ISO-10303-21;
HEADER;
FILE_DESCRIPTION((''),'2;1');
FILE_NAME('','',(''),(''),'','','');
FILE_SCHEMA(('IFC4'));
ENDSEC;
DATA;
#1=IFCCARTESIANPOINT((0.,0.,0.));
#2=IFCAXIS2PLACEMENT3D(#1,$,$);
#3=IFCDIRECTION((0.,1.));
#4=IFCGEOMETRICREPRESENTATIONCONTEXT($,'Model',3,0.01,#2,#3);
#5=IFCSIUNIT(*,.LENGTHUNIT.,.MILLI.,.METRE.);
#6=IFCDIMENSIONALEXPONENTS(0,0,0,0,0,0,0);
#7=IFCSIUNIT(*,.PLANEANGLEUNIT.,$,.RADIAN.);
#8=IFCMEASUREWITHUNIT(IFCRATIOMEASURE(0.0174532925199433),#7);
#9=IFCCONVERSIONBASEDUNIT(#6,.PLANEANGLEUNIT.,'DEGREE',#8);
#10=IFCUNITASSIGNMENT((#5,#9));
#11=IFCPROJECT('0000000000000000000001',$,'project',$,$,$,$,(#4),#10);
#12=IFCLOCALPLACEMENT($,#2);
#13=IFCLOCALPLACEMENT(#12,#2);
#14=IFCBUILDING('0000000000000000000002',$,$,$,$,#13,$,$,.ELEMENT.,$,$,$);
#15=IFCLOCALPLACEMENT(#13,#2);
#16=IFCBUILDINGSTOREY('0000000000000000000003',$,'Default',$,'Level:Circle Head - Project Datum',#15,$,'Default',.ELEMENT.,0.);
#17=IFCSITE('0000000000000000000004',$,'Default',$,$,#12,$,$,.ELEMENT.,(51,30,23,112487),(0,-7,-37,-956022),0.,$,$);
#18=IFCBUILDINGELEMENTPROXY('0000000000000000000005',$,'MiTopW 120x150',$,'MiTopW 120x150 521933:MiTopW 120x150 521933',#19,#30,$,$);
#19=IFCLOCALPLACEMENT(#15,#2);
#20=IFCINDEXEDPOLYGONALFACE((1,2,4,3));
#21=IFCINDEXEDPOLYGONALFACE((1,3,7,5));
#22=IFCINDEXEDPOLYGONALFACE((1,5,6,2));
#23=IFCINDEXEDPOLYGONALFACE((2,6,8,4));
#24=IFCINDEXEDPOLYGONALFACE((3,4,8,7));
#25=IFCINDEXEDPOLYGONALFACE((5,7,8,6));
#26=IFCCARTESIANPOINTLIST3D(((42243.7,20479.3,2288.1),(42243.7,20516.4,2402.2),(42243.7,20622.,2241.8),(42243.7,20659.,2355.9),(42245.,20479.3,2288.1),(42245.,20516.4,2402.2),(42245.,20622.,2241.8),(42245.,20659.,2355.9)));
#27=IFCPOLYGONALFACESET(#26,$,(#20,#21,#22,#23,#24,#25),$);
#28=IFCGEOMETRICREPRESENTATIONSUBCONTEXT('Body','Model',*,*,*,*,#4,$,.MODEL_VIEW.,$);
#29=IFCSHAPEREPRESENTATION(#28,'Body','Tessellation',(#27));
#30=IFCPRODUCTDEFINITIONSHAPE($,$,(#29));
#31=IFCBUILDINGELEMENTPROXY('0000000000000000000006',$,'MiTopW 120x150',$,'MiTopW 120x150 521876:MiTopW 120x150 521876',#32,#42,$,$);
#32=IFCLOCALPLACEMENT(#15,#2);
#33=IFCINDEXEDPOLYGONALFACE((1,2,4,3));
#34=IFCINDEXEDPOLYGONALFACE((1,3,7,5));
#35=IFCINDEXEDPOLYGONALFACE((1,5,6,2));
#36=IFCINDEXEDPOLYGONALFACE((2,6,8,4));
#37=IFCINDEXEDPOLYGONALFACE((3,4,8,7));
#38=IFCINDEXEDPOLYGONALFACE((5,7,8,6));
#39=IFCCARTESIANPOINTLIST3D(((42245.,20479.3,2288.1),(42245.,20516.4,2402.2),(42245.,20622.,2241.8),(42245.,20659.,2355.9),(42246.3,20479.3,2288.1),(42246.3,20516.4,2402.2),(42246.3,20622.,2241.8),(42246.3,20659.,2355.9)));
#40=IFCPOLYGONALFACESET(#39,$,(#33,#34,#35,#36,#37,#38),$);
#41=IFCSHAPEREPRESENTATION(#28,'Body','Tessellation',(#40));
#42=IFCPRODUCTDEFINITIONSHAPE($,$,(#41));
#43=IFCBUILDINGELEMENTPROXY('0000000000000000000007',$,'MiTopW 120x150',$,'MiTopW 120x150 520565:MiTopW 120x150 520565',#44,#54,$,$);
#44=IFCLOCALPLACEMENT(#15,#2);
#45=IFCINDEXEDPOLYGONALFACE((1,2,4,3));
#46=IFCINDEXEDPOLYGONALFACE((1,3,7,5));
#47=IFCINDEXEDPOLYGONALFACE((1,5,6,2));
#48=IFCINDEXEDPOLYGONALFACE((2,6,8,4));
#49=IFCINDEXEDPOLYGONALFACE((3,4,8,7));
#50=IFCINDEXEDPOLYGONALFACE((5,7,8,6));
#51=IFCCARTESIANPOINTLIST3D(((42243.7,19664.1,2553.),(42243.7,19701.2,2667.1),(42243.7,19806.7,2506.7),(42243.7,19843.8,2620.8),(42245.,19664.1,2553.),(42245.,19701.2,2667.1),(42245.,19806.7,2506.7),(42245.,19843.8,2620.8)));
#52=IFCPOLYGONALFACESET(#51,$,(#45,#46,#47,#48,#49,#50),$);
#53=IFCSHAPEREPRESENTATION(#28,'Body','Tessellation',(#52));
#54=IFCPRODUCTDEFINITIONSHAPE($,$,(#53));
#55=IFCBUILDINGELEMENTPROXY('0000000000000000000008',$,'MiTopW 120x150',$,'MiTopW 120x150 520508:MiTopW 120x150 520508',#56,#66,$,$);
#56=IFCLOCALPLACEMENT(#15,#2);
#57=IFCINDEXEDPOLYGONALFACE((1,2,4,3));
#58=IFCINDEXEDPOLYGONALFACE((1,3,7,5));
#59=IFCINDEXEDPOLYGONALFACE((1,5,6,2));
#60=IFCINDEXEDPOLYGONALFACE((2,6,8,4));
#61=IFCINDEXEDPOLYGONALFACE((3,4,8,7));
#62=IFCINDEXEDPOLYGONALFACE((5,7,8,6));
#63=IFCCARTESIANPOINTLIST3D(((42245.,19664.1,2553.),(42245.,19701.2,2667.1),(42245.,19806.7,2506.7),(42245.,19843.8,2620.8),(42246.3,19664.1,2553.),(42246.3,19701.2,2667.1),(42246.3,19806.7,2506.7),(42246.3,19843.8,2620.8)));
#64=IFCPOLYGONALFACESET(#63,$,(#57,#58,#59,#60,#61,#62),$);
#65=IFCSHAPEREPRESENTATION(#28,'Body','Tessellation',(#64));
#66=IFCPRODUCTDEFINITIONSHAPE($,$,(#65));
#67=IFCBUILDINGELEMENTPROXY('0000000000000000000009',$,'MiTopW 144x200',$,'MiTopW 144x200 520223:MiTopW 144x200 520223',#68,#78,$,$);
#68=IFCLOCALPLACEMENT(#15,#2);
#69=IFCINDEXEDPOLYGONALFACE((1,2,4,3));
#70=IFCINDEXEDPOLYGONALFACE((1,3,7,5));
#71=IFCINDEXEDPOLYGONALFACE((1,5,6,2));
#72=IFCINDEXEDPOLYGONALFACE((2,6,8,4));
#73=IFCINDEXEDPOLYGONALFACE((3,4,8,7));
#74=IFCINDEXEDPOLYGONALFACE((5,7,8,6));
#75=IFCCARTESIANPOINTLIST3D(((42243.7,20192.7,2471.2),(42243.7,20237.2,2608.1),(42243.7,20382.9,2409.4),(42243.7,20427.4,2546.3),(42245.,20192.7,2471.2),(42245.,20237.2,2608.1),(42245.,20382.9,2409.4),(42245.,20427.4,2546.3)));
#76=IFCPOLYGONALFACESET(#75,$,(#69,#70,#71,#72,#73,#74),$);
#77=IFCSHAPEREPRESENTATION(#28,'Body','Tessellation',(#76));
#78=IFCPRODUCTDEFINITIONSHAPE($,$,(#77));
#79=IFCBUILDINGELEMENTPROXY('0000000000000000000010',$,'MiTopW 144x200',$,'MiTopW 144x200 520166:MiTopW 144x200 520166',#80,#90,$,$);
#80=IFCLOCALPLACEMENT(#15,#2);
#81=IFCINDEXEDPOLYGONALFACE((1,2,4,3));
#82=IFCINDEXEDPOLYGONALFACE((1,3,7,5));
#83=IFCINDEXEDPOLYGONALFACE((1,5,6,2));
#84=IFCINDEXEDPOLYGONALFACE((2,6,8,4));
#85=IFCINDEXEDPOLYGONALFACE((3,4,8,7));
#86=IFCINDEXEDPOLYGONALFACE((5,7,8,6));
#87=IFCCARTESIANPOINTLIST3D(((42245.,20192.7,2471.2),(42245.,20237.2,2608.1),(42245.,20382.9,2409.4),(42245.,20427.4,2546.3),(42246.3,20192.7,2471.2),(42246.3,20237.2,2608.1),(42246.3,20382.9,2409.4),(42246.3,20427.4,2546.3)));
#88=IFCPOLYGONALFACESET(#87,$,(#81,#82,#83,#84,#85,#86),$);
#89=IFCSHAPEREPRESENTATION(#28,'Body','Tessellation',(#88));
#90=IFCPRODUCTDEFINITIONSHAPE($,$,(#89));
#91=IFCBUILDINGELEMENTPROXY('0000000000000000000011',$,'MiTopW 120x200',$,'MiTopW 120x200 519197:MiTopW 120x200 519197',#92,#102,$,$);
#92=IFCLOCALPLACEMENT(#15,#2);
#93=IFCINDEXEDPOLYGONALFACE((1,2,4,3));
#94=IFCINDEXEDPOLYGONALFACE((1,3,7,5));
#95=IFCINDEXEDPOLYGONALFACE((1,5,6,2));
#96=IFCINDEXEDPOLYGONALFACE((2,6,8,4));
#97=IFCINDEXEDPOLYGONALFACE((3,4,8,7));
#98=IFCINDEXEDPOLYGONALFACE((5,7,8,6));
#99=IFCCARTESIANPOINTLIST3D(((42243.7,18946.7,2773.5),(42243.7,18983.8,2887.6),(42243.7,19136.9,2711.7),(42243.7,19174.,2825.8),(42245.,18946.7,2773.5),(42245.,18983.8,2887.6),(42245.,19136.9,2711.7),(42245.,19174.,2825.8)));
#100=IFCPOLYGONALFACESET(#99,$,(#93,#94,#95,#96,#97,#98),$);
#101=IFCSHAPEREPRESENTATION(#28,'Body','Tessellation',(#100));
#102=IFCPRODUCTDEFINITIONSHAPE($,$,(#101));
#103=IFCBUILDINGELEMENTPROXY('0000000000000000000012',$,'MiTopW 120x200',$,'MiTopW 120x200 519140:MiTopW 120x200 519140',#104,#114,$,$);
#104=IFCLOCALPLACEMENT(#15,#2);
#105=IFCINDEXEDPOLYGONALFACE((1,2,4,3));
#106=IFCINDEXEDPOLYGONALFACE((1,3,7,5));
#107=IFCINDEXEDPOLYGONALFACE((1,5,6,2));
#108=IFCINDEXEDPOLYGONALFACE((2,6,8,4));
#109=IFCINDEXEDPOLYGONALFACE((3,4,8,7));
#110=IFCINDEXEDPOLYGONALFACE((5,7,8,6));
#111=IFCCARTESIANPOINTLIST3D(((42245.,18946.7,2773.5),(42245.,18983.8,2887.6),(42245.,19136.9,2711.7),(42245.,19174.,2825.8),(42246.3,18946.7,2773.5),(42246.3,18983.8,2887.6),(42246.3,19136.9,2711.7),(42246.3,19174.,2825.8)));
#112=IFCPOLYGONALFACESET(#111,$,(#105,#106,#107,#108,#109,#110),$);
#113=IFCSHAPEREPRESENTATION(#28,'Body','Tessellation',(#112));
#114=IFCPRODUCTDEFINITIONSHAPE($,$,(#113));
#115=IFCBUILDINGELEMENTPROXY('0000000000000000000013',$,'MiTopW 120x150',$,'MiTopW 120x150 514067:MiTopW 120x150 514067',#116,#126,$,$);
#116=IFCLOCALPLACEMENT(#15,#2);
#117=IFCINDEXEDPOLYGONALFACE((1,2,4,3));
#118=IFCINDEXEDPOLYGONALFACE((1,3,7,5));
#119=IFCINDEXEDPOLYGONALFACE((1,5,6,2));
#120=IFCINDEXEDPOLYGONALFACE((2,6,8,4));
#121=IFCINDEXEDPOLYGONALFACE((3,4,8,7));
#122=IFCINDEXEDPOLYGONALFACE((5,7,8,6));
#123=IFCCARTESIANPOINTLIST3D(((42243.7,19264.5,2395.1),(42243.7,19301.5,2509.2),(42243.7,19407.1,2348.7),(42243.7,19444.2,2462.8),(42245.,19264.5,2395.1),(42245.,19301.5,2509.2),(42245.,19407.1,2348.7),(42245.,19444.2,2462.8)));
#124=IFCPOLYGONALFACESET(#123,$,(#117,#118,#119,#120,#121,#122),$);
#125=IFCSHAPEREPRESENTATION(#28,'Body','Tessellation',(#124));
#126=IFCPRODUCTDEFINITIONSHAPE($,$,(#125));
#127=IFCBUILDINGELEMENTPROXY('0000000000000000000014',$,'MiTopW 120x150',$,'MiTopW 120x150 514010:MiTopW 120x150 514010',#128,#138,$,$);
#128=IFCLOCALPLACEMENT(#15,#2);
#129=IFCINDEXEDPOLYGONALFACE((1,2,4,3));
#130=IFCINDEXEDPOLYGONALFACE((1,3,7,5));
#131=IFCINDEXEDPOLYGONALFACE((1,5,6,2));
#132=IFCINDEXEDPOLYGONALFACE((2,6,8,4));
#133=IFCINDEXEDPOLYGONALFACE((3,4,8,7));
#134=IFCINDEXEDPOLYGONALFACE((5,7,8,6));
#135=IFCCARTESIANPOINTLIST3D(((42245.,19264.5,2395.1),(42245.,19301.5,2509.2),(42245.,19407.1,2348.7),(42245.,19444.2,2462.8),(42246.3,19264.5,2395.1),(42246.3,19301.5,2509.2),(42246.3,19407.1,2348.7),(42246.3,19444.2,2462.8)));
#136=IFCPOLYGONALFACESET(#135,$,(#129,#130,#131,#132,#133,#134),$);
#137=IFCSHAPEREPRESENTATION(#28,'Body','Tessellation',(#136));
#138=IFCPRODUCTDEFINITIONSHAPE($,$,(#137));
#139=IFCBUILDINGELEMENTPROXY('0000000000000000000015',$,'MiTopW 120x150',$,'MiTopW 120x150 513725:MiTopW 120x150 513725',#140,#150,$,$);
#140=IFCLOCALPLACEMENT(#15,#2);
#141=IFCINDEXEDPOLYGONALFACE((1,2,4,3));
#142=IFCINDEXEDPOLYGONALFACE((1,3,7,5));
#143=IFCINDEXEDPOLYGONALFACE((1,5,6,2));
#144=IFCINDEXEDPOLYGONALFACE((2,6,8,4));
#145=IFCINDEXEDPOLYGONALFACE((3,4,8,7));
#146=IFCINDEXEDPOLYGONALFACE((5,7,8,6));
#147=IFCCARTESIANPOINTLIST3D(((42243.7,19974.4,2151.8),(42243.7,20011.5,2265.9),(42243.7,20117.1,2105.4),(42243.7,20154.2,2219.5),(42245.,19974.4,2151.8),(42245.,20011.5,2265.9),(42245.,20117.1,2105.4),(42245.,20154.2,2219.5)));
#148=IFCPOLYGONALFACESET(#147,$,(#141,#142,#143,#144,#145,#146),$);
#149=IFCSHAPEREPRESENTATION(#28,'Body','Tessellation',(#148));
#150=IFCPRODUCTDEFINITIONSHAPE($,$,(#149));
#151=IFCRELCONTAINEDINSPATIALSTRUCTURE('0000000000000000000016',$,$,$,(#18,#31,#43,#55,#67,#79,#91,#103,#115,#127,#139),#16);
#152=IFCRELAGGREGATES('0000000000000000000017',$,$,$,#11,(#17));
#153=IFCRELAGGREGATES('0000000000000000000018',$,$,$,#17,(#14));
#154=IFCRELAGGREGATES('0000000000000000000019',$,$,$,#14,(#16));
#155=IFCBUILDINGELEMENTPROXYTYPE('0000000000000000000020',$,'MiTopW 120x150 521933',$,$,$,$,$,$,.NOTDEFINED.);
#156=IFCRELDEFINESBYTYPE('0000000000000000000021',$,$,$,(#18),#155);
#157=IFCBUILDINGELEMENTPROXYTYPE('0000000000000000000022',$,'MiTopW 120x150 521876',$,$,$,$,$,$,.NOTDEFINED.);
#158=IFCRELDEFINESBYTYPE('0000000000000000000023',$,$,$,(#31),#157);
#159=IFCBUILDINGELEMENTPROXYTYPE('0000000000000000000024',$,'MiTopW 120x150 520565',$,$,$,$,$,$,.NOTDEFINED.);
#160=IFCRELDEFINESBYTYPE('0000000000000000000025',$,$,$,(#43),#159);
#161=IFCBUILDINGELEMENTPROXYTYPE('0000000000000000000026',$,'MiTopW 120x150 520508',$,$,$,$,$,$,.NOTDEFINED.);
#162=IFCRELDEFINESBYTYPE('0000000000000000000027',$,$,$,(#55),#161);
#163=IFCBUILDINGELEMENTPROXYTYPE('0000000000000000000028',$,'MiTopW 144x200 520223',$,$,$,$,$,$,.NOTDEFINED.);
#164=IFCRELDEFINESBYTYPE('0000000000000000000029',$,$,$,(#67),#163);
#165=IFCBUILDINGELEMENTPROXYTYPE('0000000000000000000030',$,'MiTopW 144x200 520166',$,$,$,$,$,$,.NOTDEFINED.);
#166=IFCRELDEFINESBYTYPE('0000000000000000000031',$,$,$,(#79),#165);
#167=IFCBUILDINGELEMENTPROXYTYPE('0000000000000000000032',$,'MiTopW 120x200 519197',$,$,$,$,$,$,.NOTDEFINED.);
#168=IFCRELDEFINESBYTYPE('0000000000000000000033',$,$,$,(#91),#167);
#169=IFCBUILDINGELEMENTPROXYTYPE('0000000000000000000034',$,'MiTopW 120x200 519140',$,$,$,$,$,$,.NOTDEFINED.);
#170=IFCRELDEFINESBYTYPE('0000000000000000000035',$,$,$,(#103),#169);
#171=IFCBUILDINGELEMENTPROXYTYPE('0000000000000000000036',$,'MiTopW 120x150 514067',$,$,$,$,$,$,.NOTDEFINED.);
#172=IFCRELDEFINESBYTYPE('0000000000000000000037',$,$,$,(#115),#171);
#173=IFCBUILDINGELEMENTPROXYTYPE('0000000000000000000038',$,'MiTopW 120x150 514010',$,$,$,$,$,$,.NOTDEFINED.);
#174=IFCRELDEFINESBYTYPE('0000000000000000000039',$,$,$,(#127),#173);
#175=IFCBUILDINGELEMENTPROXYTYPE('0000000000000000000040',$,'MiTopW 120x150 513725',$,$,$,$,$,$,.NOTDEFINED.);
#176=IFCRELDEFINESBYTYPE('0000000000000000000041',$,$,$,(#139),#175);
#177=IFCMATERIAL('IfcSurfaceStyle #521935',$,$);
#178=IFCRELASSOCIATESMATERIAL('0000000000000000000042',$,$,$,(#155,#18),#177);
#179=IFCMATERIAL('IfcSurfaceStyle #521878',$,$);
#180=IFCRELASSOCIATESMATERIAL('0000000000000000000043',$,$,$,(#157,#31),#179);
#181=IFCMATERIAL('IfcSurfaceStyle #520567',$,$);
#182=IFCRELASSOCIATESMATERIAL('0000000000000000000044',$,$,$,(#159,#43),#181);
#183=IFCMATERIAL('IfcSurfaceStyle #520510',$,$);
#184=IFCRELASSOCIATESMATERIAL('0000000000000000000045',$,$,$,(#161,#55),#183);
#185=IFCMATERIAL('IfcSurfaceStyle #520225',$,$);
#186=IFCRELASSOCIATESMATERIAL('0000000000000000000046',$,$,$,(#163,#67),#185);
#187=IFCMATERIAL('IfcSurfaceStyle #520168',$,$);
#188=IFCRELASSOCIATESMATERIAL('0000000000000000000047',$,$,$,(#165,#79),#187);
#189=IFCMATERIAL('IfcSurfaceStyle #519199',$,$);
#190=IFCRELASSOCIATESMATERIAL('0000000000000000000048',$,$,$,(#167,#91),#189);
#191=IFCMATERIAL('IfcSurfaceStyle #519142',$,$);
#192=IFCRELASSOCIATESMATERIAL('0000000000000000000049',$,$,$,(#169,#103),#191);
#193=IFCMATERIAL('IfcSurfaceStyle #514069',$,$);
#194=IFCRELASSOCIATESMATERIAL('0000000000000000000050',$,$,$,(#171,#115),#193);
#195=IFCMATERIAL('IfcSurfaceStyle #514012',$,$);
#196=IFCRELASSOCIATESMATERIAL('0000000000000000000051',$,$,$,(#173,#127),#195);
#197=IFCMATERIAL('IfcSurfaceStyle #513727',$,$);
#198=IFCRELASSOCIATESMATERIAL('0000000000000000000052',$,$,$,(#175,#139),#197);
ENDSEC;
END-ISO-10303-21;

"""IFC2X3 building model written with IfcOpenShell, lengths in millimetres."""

from ifc_helpers import new_model, entity, si_unit, converted_unit, direction, frame, origin, place, context, subcontext, project, spatial, polyline, outline, extrude, source, transform, mapped, material, type_object, type_shapes, element, save


model = new_model("IFC2X3")

# Units and contexts
model_context = context("Model", 3, precision=0.01, world=origin(), true_north=direction((0.0, 1.0)))
body_context = subcontext(model_context, "Body", "Model", "MODEL_VIEW")
ifc_project = project(units=[si_unit("LENGTHUNIT", "METRE", prefix="MILLI"), converted_unit("PLANEANGLEUNIT", "DEGREE", entity("IfcRatioMeasure", 0.0174532925199433), si_unit("PLANEANGLEUNIT", "RADIAN"), dimensions=[0, 0, 0, 0, 0, 0, 0])], contexts=[model_context])

# Site, building, storey
site_placement = place(None, origin())
site = spatial("IfcSite", under=ifc_project, at=site_placement, Name="Default", CompositionType="ELEMENT", RefLatitude=(51, 30, 23, 112487), RefLongitude=(0, -7, -37, -956022), RefElevation=0.0)
building_placement = place(site_placement, origin())
building = spatial("IfcBuilding", under=site, at=building_placement, CompositionType="ELEMENT")
storey_placement = place(building_placement, origin())
storey = spatial("IfcBuildingStorey", under=building, at=storey_placement, Name="Default", ObjectType="Level:Circle Head - Project Datum", LongName="Default", CompositionType="ELEMENT", Elevation=0.0)

# Building element proxies
ifc_material_1 = material(Name="IfcSurfaceStyle #521935")
building_element_proxy_type_1 = type_object("IfcBuildingElementProxyType", Name="MiTopW 120x150 521933", PredefinedType="NOTDEFINED", material=ifc_material_1)
shared_shape_1 = source(origin(), body_context, "Body", "SweptSolid", [
    extrude(outline(polyline([(-75.0, -60.0), (75.0, -60.0), (75.0, 60.0), (-75.0, 60.0), (-75.0, -60.0)])), frame((75.0, 60.0, 0.0), z_axis=(0.0, 0.0, 1.0), x_axis=(-1.0, 0.0, 0.0)), (0.0, 0.0, 1.0), 1.3),
])
type_shapes(building_element_proxy_type_1, [shared_shape_1])
proxy_1_placement = place(building_placement, frame((42245.0, 20622.0, 2241.8), z_axis=(-1.0, 0.0, 0.0), x_axis=(0.0, -0.951057, 0.309017)))
element("IfcBuildingElementProxy", 1, at=proxy_1_placement, inside=storey, type_object=building_element_proxy_type_1, material=ifc_material_1, Name="MiTopW 120x150", ObjectType="MiTopW 120x150 521933:MiTopW 120x150 521933", context=body_context, shape_type="MappedRepresentation", body=[
    mapped(shared_shape_1, transform((0.0, 0.0, 0.0), scale=1.0)),
])
ifc_material_2 = material(Name="IfcSurfaceStyle #521878")
building_element_proxy_type_2 = type_object("IfcBuildingElementProxyType", Name="MiTopW 120x150 521876", PredefinedType="NOTDEFINED", material=ifc_material_2)
shared_shape_2 = source(origin(), body_context, "Body", "SweptSolid", [
    extrude(outline(polyline([(-75.0, -60.0), (75.0, -60.0), (75.0, 60.0), (-75.0, 60.0), (-75.0, -60.0)])), frame((75.0, 60.0, 0.0), z_axis=(0.0, 0.0, 1.0), x_axis=(-1.0, 0.0, 0.0)), (0.0, 0.0, 1.0), 1.3),
])
type_shapes(building_element_proxy_type_2, [shared_shape_2])
proxy_2_placement = place(building_placement, frame((42246.3, 20622.0, 2241.8), z_axis=(-1.0, 0.0, 0.0), x_axis=(0.0, -0.951057, 0.309017)))
element("IfcBuildingElementProxy", 2, at=proxy_2_placement, inside=storey, type_object=building_element_proxy_type_2, material=ifc_material_2, Name="MiTopW 120x150", ObjectType="MiTopW 120x150 521876:MiTopW 120x150 521876", context=body_context, shape_type="MappedRepresentation", body=[
    mapped(shared_shape_2, transform((0.0, 0.0, 0.0), scale=1.0)),
])
ifc_material_3 = material(Name="IfcSurfaceStyle #520567")
building_element_proxy_type_3 = type_object("IfcBuildingElementProxyType", Name="MiTopW 120x150 520565", PredefinedType="NOTDEFINED", material=ifc_material_3)
shared_shape_3 = source(origin(), body_context, "Body", "SweptSolid", [
    extrude(outline(polyline([(-75.0, -60.0), (75.0, -60.0), (75.0, 60.0), (-75.0, 60.0), (-75.0, -60.0)])), frame((75.0, 60.0, 0.0), z_axis=(0.0, 0.0, 1.0), x_axis=(-1.0, 0.0, 0.0)), (0.0, 0.0, 1.0), 1.3),
])
type_shapes(building_element_proxy_type_3, [shared_shape_3])
proxy_3_placement = place(building_placement, frame((42245.0, 19806.7, 2506.7), z_axis=(-1.0, 0.0, 0.0), x_axis=(0.0, -0.951057, 0.309017)))
element("IfcBuildingElementProxy", 3, at=proxy_3_placement, inside=storey, type_object=building_element_proxy_type_3, material=ifc_material_3, Name="MiTopW 120x150", ObjectType="MiTopW 120x150 520565:MiTopW 120x150 520565", context=body_context, shape_type="MappedRepresentation", body=[
    mapped(shared_shape_3, transform((0.0, 0.0, 0.0), scale=1.0)),
])
ifc_material_4 = material(Name="IfcSurfaceStyle #520510")
building_element_proxy_type_4 = type_object("IfcBuildingElementProxyType", Name="MiTopW 120x150 520508", PredefinedType="NOTDEFINED", material=ifc_material_4)
shared_shape_4 = source(origin(), body_context, "Body", "SweptSolid", [
    extrude(outline(polyline([(-75.0, -60.0), (75.0, -60.0), (75.0, 60.0), (-75.0, 60.0), (-75.0, -60.0)])), frame((75.0, 60.0, 0.0), z_axis=(0.0, 0.0, 1.0), x_axis=(-1.0, 0.0, 0.0)), (0.0, 0.0, 1.0), 1.3),
])
type_shapes(building_element_proxy_type_4, [shared_shape_4])
proxy_4_placement = place(building_placement, frame((42246.3, 19806.7, 2506.7), z_axis=(-1.0, 0.0, 0.0), x_axis=(0.0, -0.951057, 0.309017)))
element("IfcBuildingElementProxy", 4, at=proxy_4_placement, inside=storey, type_object=building_element_proxy_type_4, material=ifc_material_4, Name="MiTopW 120x150", ObjectType="MiTopW 120x150 520508:MiTopW 120x150 520508", context=body_context, shape_type="MappedRepresentation", body=[
    mapped(shared_shape_4, transform((0.0, 0.0, 0.0), scale=1.0)),
])
ifc_material_5 = material(Name="IfcSurfaceStyle #520225")
building_element_proxy_type_5 = type_object("IfcBuildingElementProxyType", Name="MiTopW 144x200 520223", PredefinedType="NOTDEFINED", material=ifc_material_5)
shared_shape_5 = source(origin(), body_context, "Body", "SweptSolid", [
    extrude(outline(polyline([(-100.0, -72.0), (100.0, -72.0), (100.0, 72.0), (-100.0, 72.0), (-100.0, -72.0)])), frame((100.0, 72.0, 0.0), z_axis=(0.0, 0.0, 1.0), x_axis=(-1.0, 0.0, 0.0)), (0.0, 0.0, 1.0), 1.3),
])
type_shapes(building_element_proxy_type_5, [shared_shape_5])
proxy_5_placement = place(building_placement, frame((42245.0, 20382.9, 2409.4), z_axis=(-1.0, 0.0, 0.0), x_axis=(0.0, -0.951057, 0.309017)))
element("IfcBuildingElementProxy", 5, at=proxy_5_placement, inside=storey, type_object=building_element_proxy_type_5, material=ifc_material_5, Name="MiTopW 144x200", ObjectType="MiTopW 144x200 520223:MiTopW 144x200 520223", context=body_context, shape_type="MappedRepresentation", body=[
    mapped(shared_shape_5, transform((0.0, 0.0, 0.0), scale=1.0)),
])
ifc_material_6 = material(Name="IfcSurfaceStyle #520168")
building_element_proxy_type_6 = type_object("IfcBuildingElementProxyType", Name="MiTopW 144x200 520166", PredefinedType="NOTDEFINED", material=ifc_material_6)
shared_shape_6 = source(origin(), body_context, "Body", "SweptSolid", [
    extrude(outline(polyline([(-100.0, -72.0), (100.0, -72.0), (100.0, 72.0), (-100.0, 72.0), (-100.0, -72.0)])), frame((100.0, 72.0, 0.0), z_axis=(0.0, 0.0, 1.0), x_axis=(-1.0, 0.0, 0.0)), (0.0, 0.0, 1.0), 1.3),
])
type_shapes(building_element_proxy_type_6, [shared_shape_6])
proxy_6_placement = place(building_placement, frame((42246.3, 20382.9, 2409.4), z_axis=(-1.0, 0.0, 0.0), x_axis=(0.0, -0.951057, 0.309017)))
element("IfcBuildingElementProxy", 6, at=proxy_6_placement, inside=storey, type_object=building_element_proxy_type_6, material=ifc_material_6, Name="MiTopW 144x200", ObjectType="MiTopW 144x200 520166:MiTopW 144x200 520166", context=body_context, shape_type="MappedRepresentation", body=[
    mapped(shared_shape_6, transform((0.0, 0.0, 0.0), scale=1.0)),
])
ifc_material_7 = material(Name="IfcSurfaceStyle #519199")
building_element_proxy_type_7 = type_object("IfcBuildingElementProxyType", Name="MiTopW 120x200 519197", PredefinedType="NOTDEFINED", material=ifc_material_7)
shared_shape_7 = source(origin(), body_context, "Body", "SweptSolid", [
    extrude(outline(polyline([(-100.0, -60.0), (100.0, -60.0), (100.0, 60.0), (-100.0, 60.0), (-100.0, -60.0)])), frame((100.0, 60.0, 0.0), z_axis=(0.0, 0.0, 1.0), x_axis=(-1.0, 0.0, 0.0)), (0.0, 0.0, 1.0), 1.3),
])
type_shapes(building_element_proxy_type_7, [shared_shape_7])
proxy_7_placement = place(building_placement, frame((42245.0, 19136.9, 2711.7), z_axis=(-1.0, 0.0, 0.0), x_axis=(0.0, -0.951057, 0.309017)))
element("IfcBuildingElementProxy", 7, at=proxy_7_placement, inside=storey, type_object=building_element_proxy_type_7, material=ifc_material_7, Name="MiTopW 120x200", ObjectType="MiTopW 120x200 519197:MiTopW 120x200 519197", context=body_context, shape_type="MappedRepresentation", body=[
    mapped(shared_shape_7, transform((0.0, 0.0, 0.0), scale=1.0)),
])
ifc_material_8 = material(Name="IfcSurfaceStyle #519142")
building_element_proxy_type_8 = type_object("IfcBuildingElementProxyType", Name="MiTopW 120x200 519140", PredefinedType="NOTDEFINED", material=ifc_material_8)
shared_shape_8 = source(origin(), body_context, "Body", "SweptSolid", [
    extrude(outline(polyline([(-100.0, -60.0), (100.0, -60.0), (100.0, 60.0), (-100.0, 60.0), (-100.0, -60.0)])), frame((100.0, 60.0, 0.0), z_axis=(0.0, 0.0, 1.0), x_axis=(-1.0, 0.0, 0.0)), (0.0, 0.0, 1.0), 1.3),
])
type_shapes(building_element_proxy_type_8, [shared_shape_8])
proxy_8_placement = place(building_placement, frame((42246.3, 19136.9, 2711.7), z_axis=(-1.0, 0.0, 0.0), x_axis=(0.0, -0.951057, 0.309017)))
element("IfcBuildingElementProxy", 8, at=proxy_8_placement, inside=storey, type_object=building_element_proxy_type_8, material=ifc_material_8, Name="MiTopW 120x200", ObjectType="MiTopW 120x200 519140:MiTopW 120x200 519140", context=body_context, shape_type="MappedRepresentation", body=[
    mapped(shared_shape_8, transform((0.0, 0.0, 0.0), scale=1.0)),
])
ifc_material_9 = material(Name="IfcSurfaceStyle #514069")
building_element_proxy_type_9 = type_object("IfcBuildingElementProxyType", Name="MiTopW 120x150 514067", PredefinedType="NOTDEFINED", material=ifc_material_9)
shared_shape_9 = source(origin(), body_context, "Body", "SweptSolid", [
    extrude(outline(polyline([(-75.0, -60.0), (75.0, -60.0), (75.0, 60.0), (-75.0, 60.0), (-75.0, -60.0)])), frame((75.0, 60.0, 0.0), z_axis=(0.0, 0.0, 1.0), x_axis=(-1.0, 0.0, 0.0)), (0.0, 0.0, 1.0), 1.3),
])
type_shapes(building_element_proxy_type_9, [shared_shape_9])
proxy_9_placement = place(building_placement, frame((42245.0, 19407.1, 2348.7), z_axis=(-1.0, 0.0, 0.0), x_axis=(0.0, -0.951057, 0.309017)))
element("IfcBuildingElementProxy", 9, at=proxy_9_placement, inside=storey, type_object=building_element_proxy_type_9, material=ifc_material_9, Name="MiTopW 120x150", ObjectType="MiTopW 120x150 514067:MiTopW 120x150 514067", context=body_context, shape_type="MappedRepresentation", body=[
    mapped(shared_shape_9, transform((0.0, 0.0, 0.0), scale=1.0)),
])
ifc_material_10 = material(Name="IfcSurfaceStyle #514012")
building_element_proxy_type_10 = type_object("IfcBuildingElementProxyType", Name="MiTopW 120x150 514010", PredefinedType="NOTDEFINED", material=ifc_material_10)
shared_shape_10 = source(origin(), body_context, "Body", "SweptSolid", [
    extrude(outline(polyline([(-75.0, -60.0), (75.0, -60.0), (75.0, 60.0), (-75.0, 60.0), (-75.0, -60.0)])), frame((75.0, 60.0, 0.0), z_axis=(0.0, 0.0, 1.0), x_axis=(-1.0, 0.0, 0.0)), (0.0, 0.0, 1.0), 1.3),
])
type_shapes(building_element_proxy_type_10, [shared_shape_10])
proxy_10_placement = place(building_placement, frame((42246.3, 19407.1, 2348.7), z_axis=(-1.0, 0.0, 0.0), x_axis=(0.0, -0.951057, 0.309017)))
element("IfcBuildingElementProxy", 10, at=proxy_10_placement, inside=storey, type_object=building_element_proxy_type_10, material=ifc_material_10, Name="MiTopW 120x150", ObjectType="MiTopW 120x150 514010:MiTopW 120x150 514010", context=body_context, shape_type="MappedRepresentation", body=[
    mapped(shared_shape_10, transform((0.0, 0.0, 0.0), scale=1.0)),
])
ifc_material_11 = material(Name="IfcSurfaceStyle #513727")
building_element_proxy_type_11 = type_object("IfcBuildingElementProxyType", Name="MiTopW 120x150 513725", PredefinedType="NOTDEFINED", material=ifc_material_11)
shared_shape_11 = source(origin(), body_context, "Body", "SweptSolid", [
    extrude(outline(polyline([(-75.0, -60.0), (75.0, -60.0), (75.0, 60.0), (-75.0, 60.0), (-75.0, -60.0)])), frame((75.0, 60.0, 0.0), z_axis=(0.0, 0.0, 1.0), x_axis=(-1.0, 0.0, 0.0)), (0.0, 0.0, 1.0), 1.3),
])
type_shapes(building_element_proxy_type_11, [shared_shape_11])
proxy_11_placement = place(building_placement, frame((42245.0, 20117.1, 2105.4), z_axis=(-1.0, 0.0, 0.0), x_axis=(0.0, -0.951057, 0.309017)))
element("IfcBuildingElementProxy", 11, at=proxy_11_placement, inside=storey, type_object=building_element_proxy_type_11, material=ifc_material_11, Name="MiTopW 120x150", ObjectType="MiTopW 120x150 513725:MiTopW 120x150 513725", context=body_context, shape_type="MappedRepresentation", body=[
    mapped(shared_shape_11, transform((0.0, 0.0, 0.0), scale=1.0)),
])

save(model, "model.ifc")
